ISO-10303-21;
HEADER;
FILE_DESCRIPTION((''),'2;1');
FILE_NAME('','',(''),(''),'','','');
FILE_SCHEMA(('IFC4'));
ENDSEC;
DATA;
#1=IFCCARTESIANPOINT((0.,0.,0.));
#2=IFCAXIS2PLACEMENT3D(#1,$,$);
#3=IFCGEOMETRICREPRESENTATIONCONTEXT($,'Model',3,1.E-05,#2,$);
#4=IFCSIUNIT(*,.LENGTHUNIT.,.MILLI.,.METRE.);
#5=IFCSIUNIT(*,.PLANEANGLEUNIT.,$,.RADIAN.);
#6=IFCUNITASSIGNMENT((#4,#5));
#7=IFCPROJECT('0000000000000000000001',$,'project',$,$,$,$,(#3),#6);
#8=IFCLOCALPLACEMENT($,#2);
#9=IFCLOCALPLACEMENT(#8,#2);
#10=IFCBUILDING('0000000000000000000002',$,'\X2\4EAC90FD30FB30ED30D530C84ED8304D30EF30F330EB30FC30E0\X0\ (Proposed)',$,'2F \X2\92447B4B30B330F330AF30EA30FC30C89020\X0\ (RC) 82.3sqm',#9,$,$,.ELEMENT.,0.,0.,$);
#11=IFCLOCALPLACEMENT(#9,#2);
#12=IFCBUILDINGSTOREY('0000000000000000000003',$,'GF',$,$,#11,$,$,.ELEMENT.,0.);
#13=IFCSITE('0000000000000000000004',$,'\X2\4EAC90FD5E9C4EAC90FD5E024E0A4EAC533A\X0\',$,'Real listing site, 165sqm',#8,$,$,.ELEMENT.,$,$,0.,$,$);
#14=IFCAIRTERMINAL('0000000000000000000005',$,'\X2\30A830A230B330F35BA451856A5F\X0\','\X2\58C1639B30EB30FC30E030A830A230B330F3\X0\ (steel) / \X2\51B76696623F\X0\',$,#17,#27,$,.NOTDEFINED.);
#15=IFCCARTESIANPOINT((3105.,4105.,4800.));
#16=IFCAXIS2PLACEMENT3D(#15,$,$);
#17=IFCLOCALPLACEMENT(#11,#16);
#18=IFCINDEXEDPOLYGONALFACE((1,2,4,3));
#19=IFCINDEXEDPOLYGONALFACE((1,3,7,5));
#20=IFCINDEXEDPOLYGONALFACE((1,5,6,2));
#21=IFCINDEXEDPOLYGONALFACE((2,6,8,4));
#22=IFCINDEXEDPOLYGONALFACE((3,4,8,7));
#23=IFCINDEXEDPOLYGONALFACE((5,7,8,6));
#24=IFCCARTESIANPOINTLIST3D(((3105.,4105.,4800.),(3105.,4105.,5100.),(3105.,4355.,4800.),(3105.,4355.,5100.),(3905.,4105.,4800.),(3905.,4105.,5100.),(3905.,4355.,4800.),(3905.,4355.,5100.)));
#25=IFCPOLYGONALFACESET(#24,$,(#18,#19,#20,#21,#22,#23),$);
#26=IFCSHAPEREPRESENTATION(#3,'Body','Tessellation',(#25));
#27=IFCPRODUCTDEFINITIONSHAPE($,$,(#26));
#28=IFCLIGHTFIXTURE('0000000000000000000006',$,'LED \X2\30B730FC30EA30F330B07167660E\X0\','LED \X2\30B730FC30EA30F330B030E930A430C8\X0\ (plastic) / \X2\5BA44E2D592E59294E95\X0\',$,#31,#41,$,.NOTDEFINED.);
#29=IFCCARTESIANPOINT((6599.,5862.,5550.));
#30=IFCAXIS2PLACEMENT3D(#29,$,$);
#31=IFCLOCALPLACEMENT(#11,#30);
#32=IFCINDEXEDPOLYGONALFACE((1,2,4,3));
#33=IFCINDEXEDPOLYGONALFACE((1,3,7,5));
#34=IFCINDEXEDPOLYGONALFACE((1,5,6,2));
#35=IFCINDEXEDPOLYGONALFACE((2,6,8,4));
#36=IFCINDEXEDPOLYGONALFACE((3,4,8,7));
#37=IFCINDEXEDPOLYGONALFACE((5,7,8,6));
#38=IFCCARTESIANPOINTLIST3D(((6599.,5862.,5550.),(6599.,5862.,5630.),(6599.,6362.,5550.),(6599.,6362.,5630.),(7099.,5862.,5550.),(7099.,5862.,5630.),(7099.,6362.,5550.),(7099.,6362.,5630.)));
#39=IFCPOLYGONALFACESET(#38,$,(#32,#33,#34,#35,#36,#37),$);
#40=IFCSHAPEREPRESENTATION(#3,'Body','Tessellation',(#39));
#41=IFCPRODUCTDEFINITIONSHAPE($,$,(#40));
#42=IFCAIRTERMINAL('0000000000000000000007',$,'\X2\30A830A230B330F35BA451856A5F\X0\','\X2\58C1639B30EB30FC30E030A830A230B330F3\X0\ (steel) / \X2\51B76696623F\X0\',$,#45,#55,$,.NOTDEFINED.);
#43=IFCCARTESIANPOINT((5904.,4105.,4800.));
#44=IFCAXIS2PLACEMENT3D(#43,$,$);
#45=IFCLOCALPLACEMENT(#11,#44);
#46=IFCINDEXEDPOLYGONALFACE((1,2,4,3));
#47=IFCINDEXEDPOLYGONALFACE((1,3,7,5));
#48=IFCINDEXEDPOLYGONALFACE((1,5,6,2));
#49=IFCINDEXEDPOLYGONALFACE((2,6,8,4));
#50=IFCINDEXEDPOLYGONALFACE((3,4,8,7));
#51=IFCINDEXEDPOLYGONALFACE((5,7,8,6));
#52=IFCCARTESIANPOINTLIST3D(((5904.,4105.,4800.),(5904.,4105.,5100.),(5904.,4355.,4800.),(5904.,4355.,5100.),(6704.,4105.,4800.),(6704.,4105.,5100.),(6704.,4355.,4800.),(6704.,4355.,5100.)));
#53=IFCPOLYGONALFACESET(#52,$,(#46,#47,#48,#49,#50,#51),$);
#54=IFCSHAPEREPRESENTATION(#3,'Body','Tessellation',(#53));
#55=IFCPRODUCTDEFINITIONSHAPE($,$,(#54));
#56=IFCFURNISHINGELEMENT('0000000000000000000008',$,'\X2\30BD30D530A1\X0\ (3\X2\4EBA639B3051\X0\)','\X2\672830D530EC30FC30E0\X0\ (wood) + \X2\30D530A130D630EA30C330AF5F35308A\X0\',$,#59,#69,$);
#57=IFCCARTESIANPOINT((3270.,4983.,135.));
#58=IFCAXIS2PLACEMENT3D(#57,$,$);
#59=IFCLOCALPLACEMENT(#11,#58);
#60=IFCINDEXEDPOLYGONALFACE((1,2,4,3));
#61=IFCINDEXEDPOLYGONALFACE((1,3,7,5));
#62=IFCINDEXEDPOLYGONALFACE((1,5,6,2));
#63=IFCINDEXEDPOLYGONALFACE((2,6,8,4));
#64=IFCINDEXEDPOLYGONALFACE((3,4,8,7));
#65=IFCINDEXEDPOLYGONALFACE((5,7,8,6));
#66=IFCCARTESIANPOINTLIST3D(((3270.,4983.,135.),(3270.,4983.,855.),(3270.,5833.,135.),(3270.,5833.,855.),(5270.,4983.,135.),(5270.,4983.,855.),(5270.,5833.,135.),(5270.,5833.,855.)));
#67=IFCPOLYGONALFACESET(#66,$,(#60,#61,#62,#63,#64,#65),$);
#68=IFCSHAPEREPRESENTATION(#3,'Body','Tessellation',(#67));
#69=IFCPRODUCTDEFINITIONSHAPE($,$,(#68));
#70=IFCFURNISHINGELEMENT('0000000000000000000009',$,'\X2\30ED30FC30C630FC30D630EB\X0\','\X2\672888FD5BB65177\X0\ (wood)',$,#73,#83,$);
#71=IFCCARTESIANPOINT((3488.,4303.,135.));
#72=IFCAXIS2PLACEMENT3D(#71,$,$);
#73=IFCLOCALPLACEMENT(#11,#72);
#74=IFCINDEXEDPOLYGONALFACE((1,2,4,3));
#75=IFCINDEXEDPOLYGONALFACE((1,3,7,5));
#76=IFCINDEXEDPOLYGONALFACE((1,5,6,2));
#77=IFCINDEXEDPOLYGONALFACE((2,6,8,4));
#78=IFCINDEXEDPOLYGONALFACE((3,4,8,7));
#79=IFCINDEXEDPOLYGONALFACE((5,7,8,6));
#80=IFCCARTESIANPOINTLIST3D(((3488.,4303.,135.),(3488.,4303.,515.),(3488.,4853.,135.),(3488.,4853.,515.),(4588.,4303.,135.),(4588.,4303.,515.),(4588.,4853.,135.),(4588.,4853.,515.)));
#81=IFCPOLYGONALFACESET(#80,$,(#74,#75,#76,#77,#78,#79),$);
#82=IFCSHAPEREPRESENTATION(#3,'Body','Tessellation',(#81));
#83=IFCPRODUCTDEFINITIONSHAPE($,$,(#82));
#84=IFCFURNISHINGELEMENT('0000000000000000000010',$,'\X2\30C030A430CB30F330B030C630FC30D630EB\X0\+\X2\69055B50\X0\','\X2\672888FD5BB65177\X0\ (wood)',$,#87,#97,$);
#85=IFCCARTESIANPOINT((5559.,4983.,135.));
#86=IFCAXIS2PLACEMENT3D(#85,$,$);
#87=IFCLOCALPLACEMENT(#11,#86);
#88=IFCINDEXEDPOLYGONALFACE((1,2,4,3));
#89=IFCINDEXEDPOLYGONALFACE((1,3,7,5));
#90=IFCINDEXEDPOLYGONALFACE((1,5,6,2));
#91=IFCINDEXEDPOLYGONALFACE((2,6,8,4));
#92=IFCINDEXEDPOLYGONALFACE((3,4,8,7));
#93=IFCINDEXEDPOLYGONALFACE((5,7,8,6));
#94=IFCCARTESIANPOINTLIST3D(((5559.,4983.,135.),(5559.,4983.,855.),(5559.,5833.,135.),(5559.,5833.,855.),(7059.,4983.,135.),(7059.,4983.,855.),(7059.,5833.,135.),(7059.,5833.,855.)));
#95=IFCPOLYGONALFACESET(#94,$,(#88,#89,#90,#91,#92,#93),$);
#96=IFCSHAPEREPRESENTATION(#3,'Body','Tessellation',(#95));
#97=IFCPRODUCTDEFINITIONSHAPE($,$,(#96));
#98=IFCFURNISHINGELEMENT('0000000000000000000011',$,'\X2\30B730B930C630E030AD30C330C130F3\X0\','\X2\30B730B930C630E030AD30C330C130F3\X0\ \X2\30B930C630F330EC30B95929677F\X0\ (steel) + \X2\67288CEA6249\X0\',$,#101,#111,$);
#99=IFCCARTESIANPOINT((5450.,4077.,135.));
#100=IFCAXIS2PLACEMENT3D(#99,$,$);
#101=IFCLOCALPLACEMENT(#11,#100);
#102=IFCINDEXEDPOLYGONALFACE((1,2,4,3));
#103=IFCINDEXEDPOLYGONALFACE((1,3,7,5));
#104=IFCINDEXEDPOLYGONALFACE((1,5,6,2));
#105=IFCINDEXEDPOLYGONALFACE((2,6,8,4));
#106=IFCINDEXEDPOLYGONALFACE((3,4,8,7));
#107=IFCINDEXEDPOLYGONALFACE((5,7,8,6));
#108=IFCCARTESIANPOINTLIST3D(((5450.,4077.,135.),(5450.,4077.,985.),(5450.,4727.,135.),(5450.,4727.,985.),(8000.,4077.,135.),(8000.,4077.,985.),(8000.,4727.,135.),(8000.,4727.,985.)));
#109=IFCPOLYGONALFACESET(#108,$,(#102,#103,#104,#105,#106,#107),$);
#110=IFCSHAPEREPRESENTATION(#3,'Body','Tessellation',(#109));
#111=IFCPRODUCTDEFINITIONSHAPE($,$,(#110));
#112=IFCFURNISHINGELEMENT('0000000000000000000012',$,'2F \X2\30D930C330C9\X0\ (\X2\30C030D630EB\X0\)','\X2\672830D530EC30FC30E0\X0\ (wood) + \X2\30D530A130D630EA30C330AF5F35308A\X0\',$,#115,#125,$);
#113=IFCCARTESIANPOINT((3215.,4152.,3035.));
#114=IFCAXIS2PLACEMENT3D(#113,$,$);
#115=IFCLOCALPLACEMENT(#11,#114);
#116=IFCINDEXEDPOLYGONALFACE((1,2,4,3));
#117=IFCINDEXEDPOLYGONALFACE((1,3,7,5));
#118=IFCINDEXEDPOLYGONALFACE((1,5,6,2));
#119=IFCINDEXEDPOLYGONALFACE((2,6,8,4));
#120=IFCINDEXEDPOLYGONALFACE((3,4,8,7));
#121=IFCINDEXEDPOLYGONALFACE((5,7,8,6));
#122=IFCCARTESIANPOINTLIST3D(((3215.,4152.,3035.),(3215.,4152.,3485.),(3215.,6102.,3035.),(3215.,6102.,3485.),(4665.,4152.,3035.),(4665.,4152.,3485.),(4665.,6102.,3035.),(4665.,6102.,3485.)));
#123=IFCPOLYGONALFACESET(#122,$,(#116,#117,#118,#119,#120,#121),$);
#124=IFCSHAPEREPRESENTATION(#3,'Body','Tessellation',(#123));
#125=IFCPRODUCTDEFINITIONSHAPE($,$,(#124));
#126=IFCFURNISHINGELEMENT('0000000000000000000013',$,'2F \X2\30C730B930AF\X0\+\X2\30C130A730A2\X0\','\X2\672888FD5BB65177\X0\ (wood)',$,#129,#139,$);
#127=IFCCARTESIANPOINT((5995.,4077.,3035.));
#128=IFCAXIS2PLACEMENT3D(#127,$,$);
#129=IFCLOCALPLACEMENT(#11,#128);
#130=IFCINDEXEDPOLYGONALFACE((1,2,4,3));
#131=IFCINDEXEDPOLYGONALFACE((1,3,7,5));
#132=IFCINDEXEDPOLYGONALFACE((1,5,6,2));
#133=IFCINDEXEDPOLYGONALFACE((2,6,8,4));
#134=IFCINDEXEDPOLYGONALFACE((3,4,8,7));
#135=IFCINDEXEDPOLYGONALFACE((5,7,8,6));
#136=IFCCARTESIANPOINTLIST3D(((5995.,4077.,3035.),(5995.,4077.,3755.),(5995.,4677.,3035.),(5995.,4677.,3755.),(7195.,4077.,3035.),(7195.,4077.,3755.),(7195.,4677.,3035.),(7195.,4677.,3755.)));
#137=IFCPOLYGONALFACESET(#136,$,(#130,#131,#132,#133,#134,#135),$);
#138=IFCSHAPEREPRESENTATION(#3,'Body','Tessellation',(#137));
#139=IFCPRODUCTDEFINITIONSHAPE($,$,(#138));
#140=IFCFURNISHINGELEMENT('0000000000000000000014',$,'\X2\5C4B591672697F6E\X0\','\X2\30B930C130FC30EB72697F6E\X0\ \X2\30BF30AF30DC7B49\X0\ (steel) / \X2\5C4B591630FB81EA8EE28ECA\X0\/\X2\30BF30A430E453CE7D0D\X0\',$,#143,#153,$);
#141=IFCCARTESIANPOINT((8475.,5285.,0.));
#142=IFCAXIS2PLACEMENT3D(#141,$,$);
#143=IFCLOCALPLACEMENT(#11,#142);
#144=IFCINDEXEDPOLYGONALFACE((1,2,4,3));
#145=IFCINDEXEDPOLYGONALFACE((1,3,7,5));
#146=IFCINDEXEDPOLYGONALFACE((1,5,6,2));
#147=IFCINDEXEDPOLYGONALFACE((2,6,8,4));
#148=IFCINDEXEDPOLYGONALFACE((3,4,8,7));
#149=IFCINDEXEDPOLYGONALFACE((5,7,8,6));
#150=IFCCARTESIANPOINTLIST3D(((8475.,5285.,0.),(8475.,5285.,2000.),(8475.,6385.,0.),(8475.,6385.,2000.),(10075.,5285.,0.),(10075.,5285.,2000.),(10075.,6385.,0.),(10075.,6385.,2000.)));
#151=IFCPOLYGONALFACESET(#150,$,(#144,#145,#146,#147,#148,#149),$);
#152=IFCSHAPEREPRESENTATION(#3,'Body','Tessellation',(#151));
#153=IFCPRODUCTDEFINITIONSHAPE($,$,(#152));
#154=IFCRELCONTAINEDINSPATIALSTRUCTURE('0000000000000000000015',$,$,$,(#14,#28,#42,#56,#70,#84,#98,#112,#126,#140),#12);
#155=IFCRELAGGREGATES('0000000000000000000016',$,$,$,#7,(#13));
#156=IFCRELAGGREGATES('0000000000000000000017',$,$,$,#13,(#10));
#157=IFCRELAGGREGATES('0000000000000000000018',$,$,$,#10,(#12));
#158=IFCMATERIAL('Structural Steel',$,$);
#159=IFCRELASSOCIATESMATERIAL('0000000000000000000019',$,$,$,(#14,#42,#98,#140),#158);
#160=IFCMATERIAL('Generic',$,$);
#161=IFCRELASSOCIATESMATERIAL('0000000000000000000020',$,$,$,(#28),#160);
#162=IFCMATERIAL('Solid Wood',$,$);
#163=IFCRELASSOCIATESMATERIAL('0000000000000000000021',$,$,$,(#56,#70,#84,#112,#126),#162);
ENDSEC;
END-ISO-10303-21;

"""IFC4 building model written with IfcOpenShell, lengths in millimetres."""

from ifc_helpers import new_model, si_unit, frame, frame_2d, origin, place, context, project, spatial, rectangle, extrude, material, element, save


model = new_model("IFC4")

# Units and contexts
model_context = context("Model", 3, precision=1e-05, world=origin())
ifc_project = project(units=[si_unit("LENGTHUNIT", "METRE", prefix="MILLI"), si_unit("PLANEANGLEUNIT", "RADIAN")], contexts=[model_context])

# Site, building, storey
site_placement = place(None, origin())
site = spatial("IfcSite", under=ifc_project, at=site_placement, Name="京都府京都市上京区", ObjectType="Real listing site, 165sqm", CompositionType="ELEMENT", RefElevation=0.0)
building_placement = place(site_placement, origin())
building = spatial("IfcBuilding", under=site, at=building_placement, Name="京都・ロフト付きワンルーム (Proposed)", ObjectType="2F 鉄筋コンクリート造 (RC) 82.3sqm", CompositionType="ELEMENT", ElevationOfRefHeight=0.0, ElevationOfTerrain=0.0)
storey_placement = place(building_placement, origin())
storey = spatial("IfcBuildingStorey", under=building, at=storey_placement, Name="GF", CompositionType="ELEMENT", Elevation=0.0)

# Shared definitions
ifc_material_1 = material(Name="Solid Wood")

# Shared definitions
ifc_material_2 = material(Name="Generic")

# Shared definitions
ifc_material_3 = material(Name="Structural Steel")

# Air terminal
air_terminal_1_placement = place(storey_placement, frame((3105.0, 4105.0, 4800.0)))
element("IfcAirTerminal", 1, at=air_terminal_1_placement, inside=storey, material=ifc_material_3, Name="エアコン室内機", Description="壁掛ルームエアコン (steel) / 冷暖房", PredefinedType="NOTDEFINED", context=model_context, shape_type="SweptSolid", body=[
    extrude(rectangle(XDim=800.0, YDim=250.0, at=frame_2d((400.0, 125.0))), frame((3105.0, 4105.0, 4800.0)), (0.0, 0.0, 1.0), 300.0),
])

# Light fixture
light_fixture_placement = place(storey_placement, frame((6599.0, 5862.0, 5550.0)))
element("IfcLightFixture", 2, at=light_fixture_placement, inside=storey, material=ifc_material_2, Name="LED シーリング照明", Description="LED シーリングライト (plastic) / 室中央天井", PredefinedType="NOTDEFINED", context=model_context, shape_type="SweptSolid", body=[
    extrude(rectangle(XDim=500.0, YDim=500.0, at=frame_2d((250.0, 250.0))), frame((6599.0, 5862.0, 5550.0)), (0.0, 0.0, 1.0), 80.0),
])

# Air terminal
air_terminal_2_placement = place(storey_placement, frame((5904.0, 4105.0, 4800.0)))
element("IfcAirTerminal", 3, at=air_terminal_2_placement, inside=storey, material=ifc_material_3, Name="エアコン室内機", Description="壁掛ルームエアコン (steel) / 冷暖房", PredefinedType="NOTDEFINED", context=model_context, shape_type="SweptSolid", body=[
    extrude(rectangle(XDim=800.0, YDim=250.0, at=frame_2d((400.0, 125.0))), frame((5904.0, 4105.0, 4800.0)), (0.0, 0.0, 1.0), 300.0),
])

# Furnishing elements
furnishing_1_placement = place(storey_placement, frame((3270.0, 4983.0, 135.0)))
element("IfcFurnishingElement", 4, at=furnishing_1_placement, inside=storey, material=ifc_material_1, Name="ソファ (3人掛け)", Description="木フレーム (wood) + ファブリック張り", context=model_context, shape_type="SweptSolid", body=[
    extrude(rectangle(XDim=2000.0, YDim=850.0, at=frame_2d((1000.0, 425.0))), frame((3270.0, 4983.0, 135.0)), (0.0, 0.0, 1.0), 720.0),
])
furnishing_2_placement = place(storey_placement, frame((3488.0, 4303.0, 135.0)))
element("IfcFurnishingElement", 5, at=furnishing_2_placement, inside=storey, material=ifc_material_1, Name="ローテーブル", Description="木製家具 (wood)", context=model_context, shape_type="SweptSolid", body=[
    extrude(rectangle(XDim=1100.0, YDim=550.0, at=frame_2d((550.0, 275.0))), frame((3488.0, 4303.0, 135.0)), (0.0, 0.0, 1.0), 380.0),
])
furnishing_3_placement = place(storey_placement, frame((5559.0, 4983.0, 135.0)))
element("IfcFurnishingElement", 6, at=furnishing_3_placement, inside=storey, material=ifc_material_1, Name="ダイニングテーブル+椅子", Description="木製家具 (wood)", context=model_context, shape_type="SweptSolid", body=[
    extrude(rectangle(XDim=1500.0, YDim=850.0, at=frame_2d((750.0, 425.0))), frame((5559.0, 4983.0, 135.0)), (0.0, 0.0, 1.0), 720.0),
])
furnishing_4_placement = place(storey_placement, frame((5450.0, 4077.0, 135.0)))
element("IfcFurnishingElement", 7, at=furnishing_4_placement, inside=storey, material=ifc_material_3, Name="システムキッチン", Description="システムキッチン ステンレス天板 (steel) + 木質扉", context=model_context, shape_type="SweptSolid", body=[
    extrude(rectangle(XDim=2550.0, YDim=650.0, at=frame_2d((1275.0, 325.0))), frame((5450.0, 4077.0, 135.0)), (0.0, 0.0, 1.0), 850.0),
])
furnishing_5_placement = place(storey_placement, frame((3215.0, 4152.0, 3035.0)))
element("IfcFurnishingElement", 8, at=furnishing_5_placement, inside=storey, material=ifc_material_1, Name="2F ベッド (ダブル)", Description="木フレーム (wood) + ファブリック張り", context=model_context, shape_type="SweptSolid", body=[
    extrude(rectangle(XDim=1450.0, YDim=1950.0, at=frame_2d((725.0, 975.0))), frame((3215.0, 4152.0, 3035.0)), (0.0, 0.0, 1.0), 450.0),
])
furnishing_6_placement = place(storey_placement, frame((5995.0, 4077.0, 3035.0)))
element("IfcFurnishingElement", 9, at=furnishing_6_placement, inside=storey, material=ifc_material_1, Name="2F デスク+チェア", Description="木製家具 (wood)", context=model_context, shape_type="SweptSolid", body=[
    extrude(rectangle(XDim=1200.0, YDim=600.0, at=frame_2d((600.0, 300.0))), frame((5995.0, 4077.0, 3035.0)), (0.0, 0.0, 1.0), 720.0),
])
furnishing_7_placement = place(storey_placement, frame((8475.0, 5285.0, 0.0)))
element("IfcFurnishingElement", 10, at=furnishing_7_placement, inside=storey, material=ifc_material_3, Name="屋外物置", Description="スチール物置 タクボ等 (steel) / 屋外・自転車/タイヤ収納", context=model_context, shape_type="SweptSolid", body=[
    extrude(rectangle(XDim=1600.0, YDim=1100.0, at=frame_2d((800.0, 550.0))), frame((8475.0, 5285.0, 0.0)), (0.0, 0.0, 1.0), 2000.0),
])

save(model, "model.ifc")
